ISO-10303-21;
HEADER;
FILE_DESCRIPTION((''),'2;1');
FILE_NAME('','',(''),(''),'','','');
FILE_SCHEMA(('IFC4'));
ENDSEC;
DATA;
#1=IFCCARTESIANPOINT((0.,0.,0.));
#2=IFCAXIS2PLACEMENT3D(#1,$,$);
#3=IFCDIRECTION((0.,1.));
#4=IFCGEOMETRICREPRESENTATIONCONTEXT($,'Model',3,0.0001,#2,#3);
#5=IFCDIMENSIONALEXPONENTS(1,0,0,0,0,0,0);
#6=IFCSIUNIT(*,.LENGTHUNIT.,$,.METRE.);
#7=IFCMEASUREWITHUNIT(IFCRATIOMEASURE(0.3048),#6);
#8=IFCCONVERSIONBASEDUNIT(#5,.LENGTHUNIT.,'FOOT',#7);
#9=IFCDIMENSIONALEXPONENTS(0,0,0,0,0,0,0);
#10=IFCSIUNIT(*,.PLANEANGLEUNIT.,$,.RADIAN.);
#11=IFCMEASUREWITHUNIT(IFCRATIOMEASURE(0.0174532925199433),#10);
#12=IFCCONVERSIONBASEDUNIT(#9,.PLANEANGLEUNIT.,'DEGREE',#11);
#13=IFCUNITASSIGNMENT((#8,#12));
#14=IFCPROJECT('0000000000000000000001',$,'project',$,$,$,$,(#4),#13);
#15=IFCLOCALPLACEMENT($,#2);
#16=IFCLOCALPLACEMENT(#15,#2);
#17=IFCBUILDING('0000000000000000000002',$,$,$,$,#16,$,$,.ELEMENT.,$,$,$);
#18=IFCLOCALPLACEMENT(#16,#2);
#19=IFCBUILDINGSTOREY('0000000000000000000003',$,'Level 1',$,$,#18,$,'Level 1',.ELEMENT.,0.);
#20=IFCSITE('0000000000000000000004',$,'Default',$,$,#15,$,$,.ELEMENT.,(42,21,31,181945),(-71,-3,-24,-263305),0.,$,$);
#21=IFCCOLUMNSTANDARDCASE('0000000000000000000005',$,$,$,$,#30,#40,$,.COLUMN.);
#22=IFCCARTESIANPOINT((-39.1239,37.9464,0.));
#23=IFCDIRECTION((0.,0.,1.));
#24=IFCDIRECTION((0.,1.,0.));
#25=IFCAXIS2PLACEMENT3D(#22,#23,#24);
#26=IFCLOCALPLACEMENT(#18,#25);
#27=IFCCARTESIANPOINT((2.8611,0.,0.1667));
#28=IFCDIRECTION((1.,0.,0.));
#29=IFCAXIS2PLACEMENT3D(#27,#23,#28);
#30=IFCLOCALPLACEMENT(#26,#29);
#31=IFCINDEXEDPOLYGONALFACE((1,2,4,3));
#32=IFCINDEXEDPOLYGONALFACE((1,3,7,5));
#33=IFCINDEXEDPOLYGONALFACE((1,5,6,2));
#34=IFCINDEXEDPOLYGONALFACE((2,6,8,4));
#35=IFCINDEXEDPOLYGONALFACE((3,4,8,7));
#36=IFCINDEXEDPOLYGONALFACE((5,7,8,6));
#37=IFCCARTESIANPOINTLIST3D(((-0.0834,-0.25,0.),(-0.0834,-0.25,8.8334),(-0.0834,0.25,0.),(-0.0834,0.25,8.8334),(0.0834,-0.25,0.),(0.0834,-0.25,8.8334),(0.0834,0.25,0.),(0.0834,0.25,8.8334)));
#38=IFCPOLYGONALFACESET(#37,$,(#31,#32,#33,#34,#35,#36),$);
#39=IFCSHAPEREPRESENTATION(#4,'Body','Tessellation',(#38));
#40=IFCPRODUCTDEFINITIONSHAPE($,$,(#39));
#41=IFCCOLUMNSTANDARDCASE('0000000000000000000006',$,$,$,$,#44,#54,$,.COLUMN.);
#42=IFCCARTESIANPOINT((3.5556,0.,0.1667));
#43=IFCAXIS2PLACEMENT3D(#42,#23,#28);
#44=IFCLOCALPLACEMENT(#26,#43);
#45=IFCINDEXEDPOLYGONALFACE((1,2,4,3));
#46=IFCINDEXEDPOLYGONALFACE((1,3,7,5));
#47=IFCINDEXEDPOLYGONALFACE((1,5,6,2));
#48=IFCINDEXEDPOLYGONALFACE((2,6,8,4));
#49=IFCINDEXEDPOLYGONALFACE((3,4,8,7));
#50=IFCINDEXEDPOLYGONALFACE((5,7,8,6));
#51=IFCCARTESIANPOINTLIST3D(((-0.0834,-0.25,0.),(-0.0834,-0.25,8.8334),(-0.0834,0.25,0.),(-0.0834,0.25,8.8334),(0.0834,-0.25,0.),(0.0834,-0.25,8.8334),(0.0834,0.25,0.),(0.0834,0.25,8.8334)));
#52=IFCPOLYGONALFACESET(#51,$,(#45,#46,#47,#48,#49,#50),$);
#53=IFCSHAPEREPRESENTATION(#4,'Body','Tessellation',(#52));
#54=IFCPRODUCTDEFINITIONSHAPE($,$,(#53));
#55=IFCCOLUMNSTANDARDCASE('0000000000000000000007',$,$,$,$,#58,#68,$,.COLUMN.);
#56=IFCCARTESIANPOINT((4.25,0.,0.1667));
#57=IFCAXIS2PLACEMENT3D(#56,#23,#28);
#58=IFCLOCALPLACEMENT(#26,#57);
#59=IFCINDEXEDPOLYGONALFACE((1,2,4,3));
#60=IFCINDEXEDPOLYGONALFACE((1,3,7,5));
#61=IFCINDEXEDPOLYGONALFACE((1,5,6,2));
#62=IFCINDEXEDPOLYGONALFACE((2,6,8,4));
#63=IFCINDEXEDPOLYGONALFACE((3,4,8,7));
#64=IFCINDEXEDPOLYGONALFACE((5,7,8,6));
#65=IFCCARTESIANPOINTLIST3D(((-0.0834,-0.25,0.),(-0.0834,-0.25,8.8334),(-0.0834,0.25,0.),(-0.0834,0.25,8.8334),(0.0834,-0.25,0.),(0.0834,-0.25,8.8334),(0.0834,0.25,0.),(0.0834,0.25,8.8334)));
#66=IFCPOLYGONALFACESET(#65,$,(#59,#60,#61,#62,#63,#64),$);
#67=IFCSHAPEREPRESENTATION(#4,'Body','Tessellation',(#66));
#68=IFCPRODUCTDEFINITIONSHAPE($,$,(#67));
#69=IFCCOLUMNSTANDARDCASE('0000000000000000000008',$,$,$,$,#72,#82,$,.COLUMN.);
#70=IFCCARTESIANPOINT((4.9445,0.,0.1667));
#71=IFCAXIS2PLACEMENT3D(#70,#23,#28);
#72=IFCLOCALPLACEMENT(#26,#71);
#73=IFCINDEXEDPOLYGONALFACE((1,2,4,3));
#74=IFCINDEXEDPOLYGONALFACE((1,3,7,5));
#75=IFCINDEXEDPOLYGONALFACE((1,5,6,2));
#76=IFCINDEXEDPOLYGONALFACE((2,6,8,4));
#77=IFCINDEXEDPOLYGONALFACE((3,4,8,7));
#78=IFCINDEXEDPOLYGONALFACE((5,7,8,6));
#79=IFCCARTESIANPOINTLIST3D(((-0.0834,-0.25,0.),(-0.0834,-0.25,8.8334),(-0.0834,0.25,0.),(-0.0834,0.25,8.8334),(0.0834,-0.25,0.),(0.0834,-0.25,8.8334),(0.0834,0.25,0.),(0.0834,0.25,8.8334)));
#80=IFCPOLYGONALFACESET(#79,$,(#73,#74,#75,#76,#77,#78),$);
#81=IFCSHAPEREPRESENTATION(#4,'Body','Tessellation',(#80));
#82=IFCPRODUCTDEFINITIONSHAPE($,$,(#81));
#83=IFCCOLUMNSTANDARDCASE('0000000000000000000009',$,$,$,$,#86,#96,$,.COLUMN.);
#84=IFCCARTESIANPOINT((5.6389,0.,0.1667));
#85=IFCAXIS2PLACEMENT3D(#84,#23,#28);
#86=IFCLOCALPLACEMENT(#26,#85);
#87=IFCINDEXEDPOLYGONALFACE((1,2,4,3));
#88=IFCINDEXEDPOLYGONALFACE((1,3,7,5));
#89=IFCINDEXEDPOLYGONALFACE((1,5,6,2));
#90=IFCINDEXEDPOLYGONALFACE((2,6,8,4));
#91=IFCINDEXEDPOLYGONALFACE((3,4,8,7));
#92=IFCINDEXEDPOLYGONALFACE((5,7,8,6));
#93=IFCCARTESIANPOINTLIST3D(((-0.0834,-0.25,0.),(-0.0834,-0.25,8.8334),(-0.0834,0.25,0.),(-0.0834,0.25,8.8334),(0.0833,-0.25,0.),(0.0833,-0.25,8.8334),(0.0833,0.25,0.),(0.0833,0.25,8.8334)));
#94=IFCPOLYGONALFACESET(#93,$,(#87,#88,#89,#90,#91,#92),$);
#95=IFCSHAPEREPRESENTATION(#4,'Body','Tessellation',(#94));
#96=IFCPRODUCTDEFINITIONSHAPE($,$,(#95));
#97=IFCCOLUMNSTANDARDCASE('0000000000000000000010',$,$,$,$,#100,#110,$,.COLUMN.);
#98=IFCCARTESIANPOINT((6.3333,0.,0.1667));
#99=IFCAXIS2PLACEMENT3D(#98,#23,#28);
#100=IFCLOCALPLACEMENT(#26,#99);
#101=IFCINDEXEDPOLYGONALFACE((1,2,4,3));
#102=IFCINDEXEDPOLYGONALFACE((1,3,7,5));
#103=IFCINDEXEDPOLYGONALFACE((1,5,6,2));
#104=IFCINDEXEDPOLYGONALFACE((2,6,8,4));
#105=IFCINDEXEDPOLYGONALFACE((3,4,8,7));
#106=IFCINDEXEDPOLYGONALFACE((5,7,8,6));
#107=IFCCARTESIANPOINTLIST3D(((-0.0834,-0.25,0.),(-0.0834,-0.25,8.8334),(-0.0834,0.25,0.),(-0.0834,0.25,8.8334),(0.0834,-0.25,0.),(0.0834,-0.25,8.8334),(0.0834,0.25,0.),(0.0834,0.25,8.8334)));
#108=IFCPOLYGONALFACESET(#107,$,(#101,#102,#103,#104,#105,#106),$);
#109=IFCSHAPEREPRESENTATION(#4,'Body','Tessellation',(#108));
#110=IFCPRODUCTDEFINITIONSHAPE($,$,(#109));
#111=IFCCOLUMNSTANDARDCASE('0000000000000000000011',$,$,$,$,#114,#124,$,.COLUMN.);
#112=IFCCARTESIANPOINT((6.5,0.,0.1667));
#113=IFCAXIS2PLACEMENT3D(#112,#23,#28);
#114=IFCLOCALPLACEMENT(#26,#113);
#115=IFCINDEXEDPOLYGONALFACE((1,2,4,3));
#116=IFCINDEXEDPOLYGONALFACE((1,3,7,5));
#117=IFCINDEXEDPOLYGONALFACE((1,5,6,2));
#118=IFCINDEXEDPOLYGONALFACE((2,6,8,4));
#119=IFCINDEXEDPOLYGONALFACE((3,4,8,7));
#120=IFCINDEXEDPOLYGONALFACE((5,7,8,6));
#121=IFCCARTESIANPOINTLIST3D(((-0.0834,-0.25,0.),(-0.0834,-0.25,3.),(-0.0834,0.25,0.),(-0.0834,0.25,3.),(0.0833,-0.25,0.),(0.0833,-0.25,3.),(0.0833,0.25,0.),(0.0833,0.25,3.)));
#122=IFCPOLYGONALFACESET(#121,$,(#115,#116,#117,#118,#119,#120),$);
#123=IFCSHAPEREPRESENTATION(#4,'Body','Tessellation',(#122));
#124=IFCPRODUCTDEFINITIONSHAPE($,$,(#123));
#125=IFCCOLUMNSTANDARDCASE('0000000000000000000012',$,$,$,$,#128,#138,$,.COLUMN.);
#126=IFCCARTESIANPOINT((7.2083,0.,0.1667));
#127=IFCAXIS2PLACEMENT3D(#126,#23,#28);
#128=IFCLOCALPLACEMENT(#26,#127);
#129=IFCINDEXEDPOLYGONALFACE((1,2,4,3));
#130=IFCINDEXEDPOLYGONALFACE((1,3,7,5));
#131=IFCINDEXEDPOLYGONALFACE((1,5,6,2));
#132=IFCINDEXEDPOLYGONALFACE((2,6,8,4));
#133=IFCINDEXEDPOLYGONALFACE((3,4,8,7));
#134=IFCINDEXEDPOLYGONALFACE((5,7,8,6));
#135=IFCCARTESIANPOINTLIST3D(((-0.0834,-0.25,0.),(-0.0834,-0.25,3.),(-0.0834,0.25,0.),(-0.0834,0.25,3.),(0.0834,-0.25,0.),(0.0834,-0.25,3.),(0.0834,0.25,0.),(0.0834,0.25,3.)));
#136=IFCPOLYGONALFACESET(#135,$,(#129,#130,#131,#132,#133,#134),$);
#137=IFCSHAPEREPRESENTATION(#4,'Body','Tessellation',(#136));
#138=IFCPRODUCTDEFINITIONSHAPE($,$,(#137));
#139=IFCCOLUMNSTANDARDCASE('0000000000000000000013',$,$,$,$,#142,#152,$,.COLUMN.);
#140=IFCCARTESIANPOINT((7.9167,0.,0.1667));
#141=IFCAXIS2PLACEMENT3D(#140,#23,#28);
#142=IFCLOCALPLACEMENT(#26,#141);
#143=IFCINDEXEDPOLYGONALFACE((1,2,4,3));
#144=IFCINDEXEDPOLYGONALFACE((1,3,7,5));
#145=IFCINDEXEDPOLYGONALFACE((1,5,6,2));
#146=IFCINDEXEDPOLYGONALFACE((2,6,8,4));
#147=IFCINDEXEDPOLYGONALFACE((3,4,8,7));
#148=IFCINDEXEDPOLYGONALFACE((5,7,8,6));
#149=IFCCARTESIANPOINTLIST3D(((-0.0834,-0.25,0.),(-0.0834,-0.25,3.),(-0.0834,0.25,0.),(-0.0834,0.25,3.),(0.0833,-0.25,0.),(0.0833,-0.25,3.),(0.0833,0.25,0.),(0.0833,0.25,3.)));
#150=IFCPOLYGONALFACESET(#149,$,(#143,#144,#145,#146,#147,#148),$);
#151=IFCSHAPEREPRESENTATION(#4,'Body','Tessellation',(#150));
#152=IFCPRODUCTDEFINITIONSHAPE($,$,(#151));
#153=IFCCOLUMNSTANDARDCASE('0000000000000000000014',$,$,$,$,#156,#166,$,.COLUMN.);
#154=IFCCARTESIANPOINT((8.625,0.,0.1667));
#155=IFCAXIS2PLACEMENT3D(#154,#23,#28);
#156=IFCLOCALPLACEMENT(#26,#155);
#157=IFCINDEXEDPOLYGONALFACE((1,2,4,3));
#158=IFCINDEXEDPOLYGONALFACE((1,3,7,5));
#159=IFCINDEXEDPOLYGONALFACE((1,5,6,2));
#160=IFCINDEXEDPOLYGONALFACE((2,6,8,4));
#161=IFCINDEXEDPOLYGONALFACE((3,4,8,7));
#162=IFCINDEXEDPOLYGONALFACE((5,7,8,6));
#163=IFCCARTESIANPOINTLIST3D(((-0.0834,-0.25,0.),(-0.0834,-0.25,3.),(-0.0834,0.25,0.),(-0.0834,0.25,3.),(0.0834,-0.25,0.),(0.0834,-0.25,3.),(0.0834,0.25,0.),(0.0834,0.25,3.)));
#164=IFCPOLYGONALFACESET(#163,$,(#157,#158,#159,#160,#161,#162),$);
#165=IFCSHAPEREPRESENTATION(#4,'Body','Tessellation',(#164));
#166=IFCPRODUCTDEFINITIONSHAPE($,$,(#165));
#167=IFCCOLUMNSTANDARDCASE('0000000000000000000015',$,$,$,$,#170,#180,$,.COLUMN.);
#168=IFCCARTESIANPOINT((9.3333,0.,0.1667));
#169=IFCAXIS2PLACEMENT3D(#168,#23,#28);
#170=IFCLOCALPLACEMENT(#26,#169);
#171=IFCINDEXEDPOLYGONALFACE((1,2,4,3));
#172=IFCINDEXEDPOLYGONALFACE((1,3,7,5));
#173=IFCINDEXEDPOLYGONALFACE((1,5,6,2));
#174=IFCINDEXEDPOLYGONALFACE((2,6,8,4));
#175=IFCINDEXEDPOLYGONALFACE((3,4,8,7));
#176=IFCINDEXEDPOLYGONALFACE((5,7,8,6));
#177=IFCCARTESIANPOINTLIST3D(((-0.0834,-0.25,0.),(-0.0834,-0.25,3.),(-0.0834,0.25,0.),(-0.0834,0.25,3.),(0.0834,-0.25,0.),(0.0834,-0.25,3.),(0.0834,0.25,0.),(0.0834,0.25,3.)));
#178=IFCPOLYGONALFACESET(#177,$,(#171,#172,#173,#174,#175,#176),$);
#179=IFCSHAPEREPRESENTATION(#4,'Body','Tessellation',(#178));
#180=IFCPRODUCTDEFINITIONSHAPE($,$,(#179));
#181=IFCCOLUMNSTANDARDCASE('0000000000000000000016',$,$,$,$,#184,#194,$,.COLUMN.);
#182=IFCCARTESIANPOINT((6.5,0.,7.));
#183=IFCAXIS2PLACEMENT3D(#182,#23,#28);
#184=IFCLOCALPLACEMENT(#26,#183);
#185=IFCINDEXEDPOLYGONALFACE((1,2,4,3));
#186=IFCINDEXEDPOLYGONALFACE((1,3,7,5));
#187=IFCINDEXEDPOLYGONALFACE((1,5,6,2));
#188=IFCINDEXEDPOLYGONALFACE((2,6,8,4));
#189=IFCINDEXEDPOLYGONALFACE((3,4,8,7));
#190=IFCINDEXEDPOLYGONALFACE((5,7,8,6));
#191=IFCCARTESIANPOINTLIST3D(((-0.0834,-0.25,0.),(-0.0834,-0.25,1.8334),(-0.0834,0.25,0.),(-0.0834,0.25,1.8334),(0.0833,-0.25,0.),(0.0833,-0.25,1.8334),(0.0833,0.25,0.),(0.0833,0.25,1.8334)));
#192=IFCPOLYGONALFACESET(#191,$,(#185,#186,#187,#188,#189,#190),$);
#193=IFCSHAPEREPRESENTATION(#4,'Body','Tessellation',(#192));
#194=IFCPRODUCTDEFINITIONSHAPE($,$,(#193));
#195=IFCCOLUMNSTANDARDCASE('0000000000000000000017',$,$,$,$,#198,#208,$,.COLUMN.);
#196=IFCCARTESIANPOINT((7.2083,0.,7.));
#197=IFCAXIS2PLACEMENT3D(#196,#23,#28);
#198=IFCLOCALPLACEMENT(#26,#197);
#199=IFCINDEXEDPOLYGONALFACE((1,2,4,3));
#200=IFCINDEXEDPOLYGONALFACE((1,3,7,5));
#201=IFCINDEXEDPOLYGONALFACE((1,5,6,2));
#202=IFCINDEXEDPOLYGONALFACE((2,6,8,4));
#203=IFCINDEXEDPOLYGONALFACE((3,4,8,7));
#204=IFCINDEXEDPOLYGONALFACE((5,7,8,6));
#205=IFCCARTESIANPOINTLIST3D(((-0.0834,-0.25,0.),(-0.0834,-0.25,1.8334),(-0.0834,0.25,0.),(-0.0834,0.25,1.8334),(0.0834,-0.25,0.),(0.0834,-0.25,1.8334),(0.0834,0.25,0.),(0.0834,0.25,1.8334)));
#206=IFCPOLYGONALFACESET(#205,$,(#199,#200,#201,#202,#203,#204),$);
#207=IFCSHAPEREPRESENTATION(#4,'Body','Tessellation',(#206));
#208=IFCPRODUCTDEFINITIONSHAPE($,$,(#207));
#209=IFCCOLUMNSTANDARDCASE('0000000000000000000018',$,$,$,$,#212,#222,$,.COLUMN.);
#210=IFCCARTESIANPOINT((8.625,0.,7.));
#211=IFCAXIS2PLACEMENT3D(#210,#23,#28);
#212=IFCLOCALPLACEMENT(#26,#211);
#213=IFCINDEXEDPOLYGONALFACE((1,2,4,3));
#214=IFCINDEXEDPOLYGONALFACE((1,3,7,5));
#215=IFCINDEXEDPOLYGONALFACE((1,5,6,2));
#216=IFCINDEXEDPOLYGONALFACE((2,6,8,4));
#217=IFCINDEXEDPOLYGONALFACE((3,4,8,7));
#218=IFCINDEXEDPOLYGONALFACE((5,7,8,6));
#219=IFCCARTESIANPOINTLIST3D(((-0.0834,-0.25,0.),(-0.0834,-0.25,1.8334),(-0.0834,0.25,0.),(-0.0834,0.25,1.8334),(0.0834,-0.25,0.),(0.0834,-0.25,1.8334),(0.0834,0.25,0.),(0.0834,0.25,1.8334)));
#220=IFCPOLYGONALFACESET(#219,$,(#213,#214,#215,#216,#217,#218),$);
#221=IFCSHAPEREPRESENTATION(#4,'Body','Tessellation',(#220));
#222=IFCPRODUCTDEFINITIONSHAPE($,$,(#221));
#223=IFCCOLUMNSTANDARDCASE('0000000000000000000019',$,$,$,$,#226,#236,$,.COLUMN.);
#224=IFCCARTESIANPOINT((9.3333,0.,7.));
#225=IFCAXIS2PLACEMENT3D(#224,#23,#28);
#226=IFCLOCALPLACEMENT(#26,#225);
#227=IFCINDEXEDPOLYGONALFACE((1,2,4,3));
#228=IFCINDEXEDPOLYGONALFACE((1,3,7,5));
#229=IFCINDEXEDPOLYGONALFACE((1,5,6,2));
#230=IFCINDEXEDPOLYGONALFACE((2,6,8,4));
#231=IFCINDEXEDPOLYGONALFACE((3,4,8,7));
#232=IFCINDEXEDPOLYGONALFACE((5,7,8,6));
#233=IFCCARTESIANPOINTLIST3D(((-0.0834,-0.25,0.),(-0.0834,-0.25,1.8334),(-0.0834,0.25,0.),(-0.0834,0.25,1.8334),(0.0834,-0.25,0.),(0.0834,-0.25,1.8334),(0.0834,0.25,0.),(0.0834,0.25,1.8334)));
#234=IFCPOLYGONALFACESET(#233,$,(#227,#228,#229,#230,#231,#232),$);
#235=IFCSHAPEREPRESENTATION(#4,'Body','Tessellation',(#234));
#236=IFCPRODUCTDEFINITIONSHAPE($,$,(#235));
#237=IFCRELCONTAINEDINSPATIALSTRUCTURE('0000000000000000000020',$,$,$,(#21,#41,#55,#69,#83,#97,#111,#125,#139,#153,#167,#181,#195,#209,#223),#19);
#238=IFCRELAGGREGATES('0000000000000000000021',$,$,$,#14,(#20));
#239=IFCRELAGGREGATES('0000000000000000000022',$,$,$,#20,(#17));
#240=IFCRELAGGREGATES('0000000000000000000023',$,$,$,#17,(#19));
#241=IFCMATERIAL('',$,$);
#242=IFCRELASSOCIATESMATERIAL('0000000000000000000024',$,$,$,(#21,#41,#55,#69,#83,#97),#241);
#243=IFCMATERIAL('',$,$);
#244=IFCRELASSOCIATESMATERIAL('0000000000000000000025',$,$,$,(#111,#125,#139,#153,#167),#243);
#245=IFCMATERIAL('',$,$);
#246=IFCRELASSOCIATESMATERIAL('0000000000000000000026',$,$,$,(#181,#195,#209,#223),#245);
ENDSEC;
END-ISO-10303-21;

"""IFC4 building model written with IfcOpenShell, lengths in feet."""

from ifc_helpers import new_model, entity, si_unit, converted_unit, direction, frame, origin, place, context, project, spatial, rectangle, extrude, material, element, save


model = new_model("IFC4")

# Units and contexts
model_context = context("Model", 3, precision=0.0001, world=origin(), true_north=direction((0.0, 1.0)))
ifc_project = project(units=[converted_unit("LENGTHUNIT", "FOOT", entity("IfcRatioMeasure", 0.3048), si_unit("LENGTHUNIT", "METRE"), dimensions=[1, 0, 0, 0, 0, 0, 0]), converted_unit("PLANEANGLEUNIT", "DEGREE", entity("IfcRatioMeasure", 0.0174532925199433), si_unit("PLANEANGLEUNIT", "RADIAN"), dimensions=[0, 0, 0, 0, 0, 0, 0])], contexts=[model_context])

# Site, building, storey
site_placement = place(None, origin())
site = spatial("IfcSite", under=ifc_project, at=site_placement, Name="Default", CompositionType="ELEMENT", RefLatitude=(42, 21, 31, 181945), RefLongitude=(-71, -3, -24, -263305), RefElevation=0.0)
building_placement = place(site_placement, origin())
building = spatial("IfcBuilding", under=site, at=building_placement, CompositionType="ELEMENT")
storey_placement = place(building_placement, origin())
storey = spatial("IfcBuildingStorey", under=building, at=storey_placement, Name="Level 1", LongName="Level 1", CompositionType="ELEMENT", Elevation=0.0)

# Columns
ifc_material_1 = material(Name="")
placement_1 = place(storey_placement, frame((-39.1239, 37.9464, 0.0), z_axis=(0.0, 0.0, 1.0), x_axis=(0.0, 1.0, 0.0)))
for number, where, z_axis, x_axis in (
    (1, (2.8611, 0.0, 0.1667), (0.0, 0.0, 1.0), (1.0, 0.0, 0.0)),
    (2, (3.5556, 0.0, 0.1667), (0.0, 0.0, 1.0), (1.0, 0.0, 0.0)),
    (3, (4.25, 0.0, 0.1667), (0.0, 0.0, 1.0), (1.0, 0.0, 0.0)),
    (4, (4.9445, 0.0, 0.1667), (0.0, 0.0, 1.0), (1.0, 0.0, 0.0)),
    (5, (5.6389, 0.0, 0.1667), (0.0, 0.0, 1.0), (1.0, 0.0, 0.0)),
    (6, (6.3333, 0.0, 0.1667), (0.0, 0.0, 1.0), (1.0, 0.0, 0.0)),
):
    element("IfcColumnStandardCase", number, at=place(placement_1, frame(where, z_axis=z_axis, x_axis=x_axis)), inside=storey, material=ifc_material_1, PredefinedType="COLUMN", context=model_context, shape_type="SweptSolid", body=[
        extrude(rectangle(XDim=0.1667, YDim=0.5), origin(), (0.0, 0.0, 1.0), 8.8334),
    ])
ifc_material_2 = material(Name="")
for number, where, z_axis, x_axis in (
    (7, (6.5, 0.0, 0.1667), (0.0, 0.0, 1.0), (1.0, 0.0, 0.0)),
    (8, (7.2083, 0.0, 0.1667), (0.0, 0.0, 1.0), (1.0, 0.0, 0.0)),
    (9, (7.9167, 0.0, 0.1667), (0.0, 0.0, 1.0), (1.0, 0.0, 0.0)),
    (10, (8.625, 0.0, 0.1667), (0.0, 0.0, 1.0), (1.0, 0.0, 0.0)),
    (11, (9.3333, 0.0, 0.1667), (0.0, 0.0, 1.0), (1.0, 0.0, 0.0)),
):
    element("IfcColumnStandardCase", number, at=place(placement_1, frame(where, z_axis=z_axis, x_axis=x_axis)), inside=storey, material=ifc_material_2, PredefinedType="COLUMN", context=model_context, shape_type="SweptSolid", body=[
        extrude(rectangle(XDim=0.1667, YDim=0.5), origin(), (0.0, 0.0, 1.0), 3.0),
    ])
ifc_material_3 = material(Name="")
for number, where, z_axis, x_axis in (
    (12, (6.5, 0.0, 7.0), (0.0, 0.0, 1.0), (1.0, 0.0, 0.0)),
    (13, (7.2083, 0.0, 7.0), (0.0, 0.0, 1.0), (1.0, 0.0, 0.0)),
    (14, (8.625, 0.0, 7.0), (0.0, 0.0, 1.0), (1.0, 0.0, 0.0)),
    (15, (9.3333, 0.0, 7.0), (0.0, 0.0, 1.0), (1.0, 0.0, 0.0)),
):
    element("IfcColumnStandardCase", number, at=place(placement_1, frame(where, z_axis=z_axis, x_axis=x_axis)), inside=storey, material=ifc_material_3, PredefinedType="COLUMN", context=model_context, shape_type="SweptSolid", body=[
        extrude(rectangle(XDim=0.1667, YDim=0.5), origin(), (0.0, 0.0, 1.0), 1.8334),
    ])

save(model, "model.ifc")
